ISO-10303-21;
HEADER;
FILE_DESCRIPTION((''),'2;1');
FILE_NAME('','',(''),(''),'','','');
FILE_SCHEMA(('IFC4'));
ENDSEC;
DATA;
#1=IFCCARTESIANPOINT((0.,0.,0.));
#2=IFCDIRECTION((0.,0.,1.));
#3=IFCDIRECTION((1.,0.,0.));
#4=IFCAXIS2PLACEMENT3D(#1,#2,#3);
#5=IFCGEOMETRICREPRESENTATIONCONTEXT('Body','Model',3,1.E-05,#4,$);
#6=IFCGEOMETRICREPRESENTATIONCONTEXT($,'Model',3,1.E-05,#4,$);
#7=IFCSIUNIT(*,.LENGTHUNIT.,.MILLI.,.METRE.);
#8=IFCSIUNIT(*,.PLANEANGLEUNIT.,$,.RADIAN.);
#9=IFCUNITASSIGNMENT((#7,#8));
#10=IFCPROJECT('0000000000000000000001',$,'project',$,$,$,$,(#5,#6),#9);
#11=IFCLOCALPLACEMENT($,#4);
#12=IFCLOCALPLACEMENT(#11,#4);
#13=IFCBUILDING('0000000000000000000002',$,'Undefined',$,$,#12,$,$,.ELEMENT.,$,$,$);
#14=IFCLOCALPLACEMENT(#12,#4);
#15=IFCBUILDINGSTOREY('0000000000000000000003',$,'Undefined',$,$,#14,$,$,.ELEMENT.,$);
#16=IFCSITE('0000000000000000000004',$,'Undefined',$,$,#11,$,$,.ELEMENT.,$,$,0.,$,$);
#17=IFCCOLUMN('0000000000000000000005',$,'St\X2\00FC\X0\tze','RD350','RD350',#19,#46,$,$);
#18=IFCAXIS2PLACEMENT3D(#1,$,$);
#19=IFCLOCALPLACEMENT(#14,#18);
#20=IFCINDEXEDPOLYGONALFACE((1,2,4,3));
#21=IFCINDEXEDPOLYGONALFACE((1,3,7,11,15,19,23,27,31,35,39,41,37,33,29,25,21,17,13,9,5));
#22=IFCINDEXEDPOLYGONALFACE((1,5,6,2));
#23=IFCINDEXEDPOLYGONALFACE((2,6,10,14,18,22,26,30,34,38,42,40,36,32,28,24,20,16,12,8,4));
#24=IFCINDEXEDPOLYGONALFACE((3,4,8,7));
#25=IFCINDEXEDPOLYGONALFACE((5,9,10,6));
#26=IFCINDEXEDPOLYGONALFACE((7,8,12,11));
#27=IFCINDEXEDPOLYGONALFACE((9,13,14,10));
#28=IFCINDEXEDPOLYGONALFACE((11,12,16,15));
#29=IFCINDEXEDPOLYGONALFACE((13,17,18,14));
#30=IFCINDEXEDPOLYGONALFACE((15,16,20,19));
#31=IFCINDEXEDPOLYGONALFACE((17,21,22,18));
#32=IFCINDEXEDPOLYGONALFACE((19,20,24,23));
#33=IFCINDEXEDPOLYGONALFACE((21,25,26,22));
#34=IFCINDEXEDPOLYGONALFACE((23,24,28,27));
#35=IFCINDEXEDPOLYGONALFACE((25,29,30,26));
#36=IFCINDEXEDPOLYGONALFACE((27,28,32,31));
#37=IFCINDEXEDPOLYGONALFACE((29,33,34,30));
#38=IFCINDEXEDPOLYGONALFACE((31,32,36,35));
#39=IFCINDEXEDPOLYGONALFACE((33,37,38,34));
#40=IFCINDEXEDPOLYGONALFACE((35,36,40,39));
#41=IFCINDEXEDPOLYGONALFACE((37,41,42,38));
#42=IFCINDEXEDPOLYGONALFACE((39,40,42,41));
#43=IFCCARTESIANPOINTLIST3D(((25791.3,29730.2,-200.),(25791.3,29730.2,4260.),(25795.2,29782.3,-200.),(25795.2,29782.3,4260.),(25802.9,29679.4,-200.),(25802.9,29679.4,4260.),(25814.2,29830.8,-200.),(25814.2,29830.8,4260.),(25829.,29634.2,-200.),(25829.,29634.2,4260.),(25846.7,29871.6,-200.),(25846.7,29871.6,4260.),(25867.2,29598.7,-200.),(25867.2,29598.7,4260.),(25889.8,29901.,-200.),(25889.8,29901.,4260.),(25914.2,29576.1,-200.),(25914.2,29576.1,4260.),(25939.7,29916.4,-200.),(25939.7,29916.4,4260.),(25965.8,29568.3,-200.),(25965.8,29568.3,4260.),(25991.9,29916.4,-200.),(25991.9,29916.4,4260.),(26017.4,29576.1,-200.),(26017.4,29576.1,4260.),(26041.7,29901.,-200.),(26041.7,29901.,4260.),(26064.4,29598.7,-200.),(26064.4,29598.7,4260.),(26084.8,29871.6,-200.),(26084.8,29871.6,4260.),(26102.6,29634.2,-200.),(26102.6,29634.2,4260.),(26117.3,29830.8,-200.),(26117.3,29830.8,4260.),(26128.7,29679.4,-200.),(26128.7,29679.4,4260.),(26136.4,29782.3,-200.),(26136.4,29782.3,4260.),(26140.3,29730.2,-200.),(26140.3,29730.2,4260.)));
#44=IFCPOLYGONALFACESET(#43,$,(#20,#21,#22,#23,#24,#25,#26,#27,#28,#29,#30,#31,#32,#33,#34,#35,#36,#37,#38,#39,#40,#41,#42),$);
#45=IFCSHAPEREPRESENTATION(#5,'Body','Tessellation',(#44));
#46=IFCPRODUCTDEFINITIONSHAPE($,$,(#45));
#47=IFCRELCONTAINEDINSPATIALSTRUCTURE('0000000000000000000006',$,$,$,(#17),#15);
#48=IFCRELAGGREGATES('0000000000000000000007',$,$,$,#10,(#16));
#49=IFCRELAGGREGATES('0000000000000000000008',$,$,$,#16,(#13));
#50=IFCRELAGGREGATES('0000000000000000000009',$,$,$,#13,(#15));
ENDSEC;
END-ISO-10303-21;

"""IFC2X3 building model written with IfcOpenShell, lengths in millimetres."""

from ifc_helpers import new_model, si_unit, frame, origin_with_axes, origin_2d_with_axis, place, context, project, spatial, circle, extrude, element, save


model = new_model("IFC2X3")

# Units and contexts
model_context_1 = context("Model", 3, precision=1e-05, world=origin_with_axes(), identifier="Body")
model_context_2 = context("Model", 3, precision=1e-05, world=origin_with_axes())
ifc_project = project(units=[si_unit("LENGTHUNIT", "METRE", prefix="MILLI"), si_unit("PLANEANGLEUNIT", "RADIAN")], contexts=[model_context_1, model_context_2])

# Site, building, storey
site_placement = place(None, origin_with_axes())
site = spatial("IfcSite", under=ifc_project, at=site_placement, Name="Undefined", CompositionType="ELEMENT", RefElevation=0.0)
building_placement = place(site_placement, origin_with_axes())
building = spatial("IfcBuilding", under=site, at=building_placement, Name="Undefined", CompositionType="ELEMENT")
storey_placement = place(building_placement, origin_with_axes())
storey = spatial("IfcBuildingStorey", under=building, at=storey_placement, Name="Undefined", CompositionType="ELEMENT")

# Column
column_1_placement = place(storey_placement, frame((25965.8, 29743.3, -200.0), z_axis=(0.0, 0.0, 1.0), x_axis=(1.0, 0.0, 0.0)))
element("IfcColumn", 1, at=column_1_placement, inside=storey, Name="Stütze", Description="RD350", ObjectType="RD350", context=model_context_1, shape_type="SweptSolid", body=[
    extrude(circle(Radius=175.0, at=origin_2d_with_axis()), frame((0.0, 0.0, 4460.0), z_axis=(0.0, 0.0, -1.0), x_axis=(-0.866025, 0.500001, 0.0)), (0.0, 0.0, 1.0), 4460.0),
])

save(model, "model.ifc")
